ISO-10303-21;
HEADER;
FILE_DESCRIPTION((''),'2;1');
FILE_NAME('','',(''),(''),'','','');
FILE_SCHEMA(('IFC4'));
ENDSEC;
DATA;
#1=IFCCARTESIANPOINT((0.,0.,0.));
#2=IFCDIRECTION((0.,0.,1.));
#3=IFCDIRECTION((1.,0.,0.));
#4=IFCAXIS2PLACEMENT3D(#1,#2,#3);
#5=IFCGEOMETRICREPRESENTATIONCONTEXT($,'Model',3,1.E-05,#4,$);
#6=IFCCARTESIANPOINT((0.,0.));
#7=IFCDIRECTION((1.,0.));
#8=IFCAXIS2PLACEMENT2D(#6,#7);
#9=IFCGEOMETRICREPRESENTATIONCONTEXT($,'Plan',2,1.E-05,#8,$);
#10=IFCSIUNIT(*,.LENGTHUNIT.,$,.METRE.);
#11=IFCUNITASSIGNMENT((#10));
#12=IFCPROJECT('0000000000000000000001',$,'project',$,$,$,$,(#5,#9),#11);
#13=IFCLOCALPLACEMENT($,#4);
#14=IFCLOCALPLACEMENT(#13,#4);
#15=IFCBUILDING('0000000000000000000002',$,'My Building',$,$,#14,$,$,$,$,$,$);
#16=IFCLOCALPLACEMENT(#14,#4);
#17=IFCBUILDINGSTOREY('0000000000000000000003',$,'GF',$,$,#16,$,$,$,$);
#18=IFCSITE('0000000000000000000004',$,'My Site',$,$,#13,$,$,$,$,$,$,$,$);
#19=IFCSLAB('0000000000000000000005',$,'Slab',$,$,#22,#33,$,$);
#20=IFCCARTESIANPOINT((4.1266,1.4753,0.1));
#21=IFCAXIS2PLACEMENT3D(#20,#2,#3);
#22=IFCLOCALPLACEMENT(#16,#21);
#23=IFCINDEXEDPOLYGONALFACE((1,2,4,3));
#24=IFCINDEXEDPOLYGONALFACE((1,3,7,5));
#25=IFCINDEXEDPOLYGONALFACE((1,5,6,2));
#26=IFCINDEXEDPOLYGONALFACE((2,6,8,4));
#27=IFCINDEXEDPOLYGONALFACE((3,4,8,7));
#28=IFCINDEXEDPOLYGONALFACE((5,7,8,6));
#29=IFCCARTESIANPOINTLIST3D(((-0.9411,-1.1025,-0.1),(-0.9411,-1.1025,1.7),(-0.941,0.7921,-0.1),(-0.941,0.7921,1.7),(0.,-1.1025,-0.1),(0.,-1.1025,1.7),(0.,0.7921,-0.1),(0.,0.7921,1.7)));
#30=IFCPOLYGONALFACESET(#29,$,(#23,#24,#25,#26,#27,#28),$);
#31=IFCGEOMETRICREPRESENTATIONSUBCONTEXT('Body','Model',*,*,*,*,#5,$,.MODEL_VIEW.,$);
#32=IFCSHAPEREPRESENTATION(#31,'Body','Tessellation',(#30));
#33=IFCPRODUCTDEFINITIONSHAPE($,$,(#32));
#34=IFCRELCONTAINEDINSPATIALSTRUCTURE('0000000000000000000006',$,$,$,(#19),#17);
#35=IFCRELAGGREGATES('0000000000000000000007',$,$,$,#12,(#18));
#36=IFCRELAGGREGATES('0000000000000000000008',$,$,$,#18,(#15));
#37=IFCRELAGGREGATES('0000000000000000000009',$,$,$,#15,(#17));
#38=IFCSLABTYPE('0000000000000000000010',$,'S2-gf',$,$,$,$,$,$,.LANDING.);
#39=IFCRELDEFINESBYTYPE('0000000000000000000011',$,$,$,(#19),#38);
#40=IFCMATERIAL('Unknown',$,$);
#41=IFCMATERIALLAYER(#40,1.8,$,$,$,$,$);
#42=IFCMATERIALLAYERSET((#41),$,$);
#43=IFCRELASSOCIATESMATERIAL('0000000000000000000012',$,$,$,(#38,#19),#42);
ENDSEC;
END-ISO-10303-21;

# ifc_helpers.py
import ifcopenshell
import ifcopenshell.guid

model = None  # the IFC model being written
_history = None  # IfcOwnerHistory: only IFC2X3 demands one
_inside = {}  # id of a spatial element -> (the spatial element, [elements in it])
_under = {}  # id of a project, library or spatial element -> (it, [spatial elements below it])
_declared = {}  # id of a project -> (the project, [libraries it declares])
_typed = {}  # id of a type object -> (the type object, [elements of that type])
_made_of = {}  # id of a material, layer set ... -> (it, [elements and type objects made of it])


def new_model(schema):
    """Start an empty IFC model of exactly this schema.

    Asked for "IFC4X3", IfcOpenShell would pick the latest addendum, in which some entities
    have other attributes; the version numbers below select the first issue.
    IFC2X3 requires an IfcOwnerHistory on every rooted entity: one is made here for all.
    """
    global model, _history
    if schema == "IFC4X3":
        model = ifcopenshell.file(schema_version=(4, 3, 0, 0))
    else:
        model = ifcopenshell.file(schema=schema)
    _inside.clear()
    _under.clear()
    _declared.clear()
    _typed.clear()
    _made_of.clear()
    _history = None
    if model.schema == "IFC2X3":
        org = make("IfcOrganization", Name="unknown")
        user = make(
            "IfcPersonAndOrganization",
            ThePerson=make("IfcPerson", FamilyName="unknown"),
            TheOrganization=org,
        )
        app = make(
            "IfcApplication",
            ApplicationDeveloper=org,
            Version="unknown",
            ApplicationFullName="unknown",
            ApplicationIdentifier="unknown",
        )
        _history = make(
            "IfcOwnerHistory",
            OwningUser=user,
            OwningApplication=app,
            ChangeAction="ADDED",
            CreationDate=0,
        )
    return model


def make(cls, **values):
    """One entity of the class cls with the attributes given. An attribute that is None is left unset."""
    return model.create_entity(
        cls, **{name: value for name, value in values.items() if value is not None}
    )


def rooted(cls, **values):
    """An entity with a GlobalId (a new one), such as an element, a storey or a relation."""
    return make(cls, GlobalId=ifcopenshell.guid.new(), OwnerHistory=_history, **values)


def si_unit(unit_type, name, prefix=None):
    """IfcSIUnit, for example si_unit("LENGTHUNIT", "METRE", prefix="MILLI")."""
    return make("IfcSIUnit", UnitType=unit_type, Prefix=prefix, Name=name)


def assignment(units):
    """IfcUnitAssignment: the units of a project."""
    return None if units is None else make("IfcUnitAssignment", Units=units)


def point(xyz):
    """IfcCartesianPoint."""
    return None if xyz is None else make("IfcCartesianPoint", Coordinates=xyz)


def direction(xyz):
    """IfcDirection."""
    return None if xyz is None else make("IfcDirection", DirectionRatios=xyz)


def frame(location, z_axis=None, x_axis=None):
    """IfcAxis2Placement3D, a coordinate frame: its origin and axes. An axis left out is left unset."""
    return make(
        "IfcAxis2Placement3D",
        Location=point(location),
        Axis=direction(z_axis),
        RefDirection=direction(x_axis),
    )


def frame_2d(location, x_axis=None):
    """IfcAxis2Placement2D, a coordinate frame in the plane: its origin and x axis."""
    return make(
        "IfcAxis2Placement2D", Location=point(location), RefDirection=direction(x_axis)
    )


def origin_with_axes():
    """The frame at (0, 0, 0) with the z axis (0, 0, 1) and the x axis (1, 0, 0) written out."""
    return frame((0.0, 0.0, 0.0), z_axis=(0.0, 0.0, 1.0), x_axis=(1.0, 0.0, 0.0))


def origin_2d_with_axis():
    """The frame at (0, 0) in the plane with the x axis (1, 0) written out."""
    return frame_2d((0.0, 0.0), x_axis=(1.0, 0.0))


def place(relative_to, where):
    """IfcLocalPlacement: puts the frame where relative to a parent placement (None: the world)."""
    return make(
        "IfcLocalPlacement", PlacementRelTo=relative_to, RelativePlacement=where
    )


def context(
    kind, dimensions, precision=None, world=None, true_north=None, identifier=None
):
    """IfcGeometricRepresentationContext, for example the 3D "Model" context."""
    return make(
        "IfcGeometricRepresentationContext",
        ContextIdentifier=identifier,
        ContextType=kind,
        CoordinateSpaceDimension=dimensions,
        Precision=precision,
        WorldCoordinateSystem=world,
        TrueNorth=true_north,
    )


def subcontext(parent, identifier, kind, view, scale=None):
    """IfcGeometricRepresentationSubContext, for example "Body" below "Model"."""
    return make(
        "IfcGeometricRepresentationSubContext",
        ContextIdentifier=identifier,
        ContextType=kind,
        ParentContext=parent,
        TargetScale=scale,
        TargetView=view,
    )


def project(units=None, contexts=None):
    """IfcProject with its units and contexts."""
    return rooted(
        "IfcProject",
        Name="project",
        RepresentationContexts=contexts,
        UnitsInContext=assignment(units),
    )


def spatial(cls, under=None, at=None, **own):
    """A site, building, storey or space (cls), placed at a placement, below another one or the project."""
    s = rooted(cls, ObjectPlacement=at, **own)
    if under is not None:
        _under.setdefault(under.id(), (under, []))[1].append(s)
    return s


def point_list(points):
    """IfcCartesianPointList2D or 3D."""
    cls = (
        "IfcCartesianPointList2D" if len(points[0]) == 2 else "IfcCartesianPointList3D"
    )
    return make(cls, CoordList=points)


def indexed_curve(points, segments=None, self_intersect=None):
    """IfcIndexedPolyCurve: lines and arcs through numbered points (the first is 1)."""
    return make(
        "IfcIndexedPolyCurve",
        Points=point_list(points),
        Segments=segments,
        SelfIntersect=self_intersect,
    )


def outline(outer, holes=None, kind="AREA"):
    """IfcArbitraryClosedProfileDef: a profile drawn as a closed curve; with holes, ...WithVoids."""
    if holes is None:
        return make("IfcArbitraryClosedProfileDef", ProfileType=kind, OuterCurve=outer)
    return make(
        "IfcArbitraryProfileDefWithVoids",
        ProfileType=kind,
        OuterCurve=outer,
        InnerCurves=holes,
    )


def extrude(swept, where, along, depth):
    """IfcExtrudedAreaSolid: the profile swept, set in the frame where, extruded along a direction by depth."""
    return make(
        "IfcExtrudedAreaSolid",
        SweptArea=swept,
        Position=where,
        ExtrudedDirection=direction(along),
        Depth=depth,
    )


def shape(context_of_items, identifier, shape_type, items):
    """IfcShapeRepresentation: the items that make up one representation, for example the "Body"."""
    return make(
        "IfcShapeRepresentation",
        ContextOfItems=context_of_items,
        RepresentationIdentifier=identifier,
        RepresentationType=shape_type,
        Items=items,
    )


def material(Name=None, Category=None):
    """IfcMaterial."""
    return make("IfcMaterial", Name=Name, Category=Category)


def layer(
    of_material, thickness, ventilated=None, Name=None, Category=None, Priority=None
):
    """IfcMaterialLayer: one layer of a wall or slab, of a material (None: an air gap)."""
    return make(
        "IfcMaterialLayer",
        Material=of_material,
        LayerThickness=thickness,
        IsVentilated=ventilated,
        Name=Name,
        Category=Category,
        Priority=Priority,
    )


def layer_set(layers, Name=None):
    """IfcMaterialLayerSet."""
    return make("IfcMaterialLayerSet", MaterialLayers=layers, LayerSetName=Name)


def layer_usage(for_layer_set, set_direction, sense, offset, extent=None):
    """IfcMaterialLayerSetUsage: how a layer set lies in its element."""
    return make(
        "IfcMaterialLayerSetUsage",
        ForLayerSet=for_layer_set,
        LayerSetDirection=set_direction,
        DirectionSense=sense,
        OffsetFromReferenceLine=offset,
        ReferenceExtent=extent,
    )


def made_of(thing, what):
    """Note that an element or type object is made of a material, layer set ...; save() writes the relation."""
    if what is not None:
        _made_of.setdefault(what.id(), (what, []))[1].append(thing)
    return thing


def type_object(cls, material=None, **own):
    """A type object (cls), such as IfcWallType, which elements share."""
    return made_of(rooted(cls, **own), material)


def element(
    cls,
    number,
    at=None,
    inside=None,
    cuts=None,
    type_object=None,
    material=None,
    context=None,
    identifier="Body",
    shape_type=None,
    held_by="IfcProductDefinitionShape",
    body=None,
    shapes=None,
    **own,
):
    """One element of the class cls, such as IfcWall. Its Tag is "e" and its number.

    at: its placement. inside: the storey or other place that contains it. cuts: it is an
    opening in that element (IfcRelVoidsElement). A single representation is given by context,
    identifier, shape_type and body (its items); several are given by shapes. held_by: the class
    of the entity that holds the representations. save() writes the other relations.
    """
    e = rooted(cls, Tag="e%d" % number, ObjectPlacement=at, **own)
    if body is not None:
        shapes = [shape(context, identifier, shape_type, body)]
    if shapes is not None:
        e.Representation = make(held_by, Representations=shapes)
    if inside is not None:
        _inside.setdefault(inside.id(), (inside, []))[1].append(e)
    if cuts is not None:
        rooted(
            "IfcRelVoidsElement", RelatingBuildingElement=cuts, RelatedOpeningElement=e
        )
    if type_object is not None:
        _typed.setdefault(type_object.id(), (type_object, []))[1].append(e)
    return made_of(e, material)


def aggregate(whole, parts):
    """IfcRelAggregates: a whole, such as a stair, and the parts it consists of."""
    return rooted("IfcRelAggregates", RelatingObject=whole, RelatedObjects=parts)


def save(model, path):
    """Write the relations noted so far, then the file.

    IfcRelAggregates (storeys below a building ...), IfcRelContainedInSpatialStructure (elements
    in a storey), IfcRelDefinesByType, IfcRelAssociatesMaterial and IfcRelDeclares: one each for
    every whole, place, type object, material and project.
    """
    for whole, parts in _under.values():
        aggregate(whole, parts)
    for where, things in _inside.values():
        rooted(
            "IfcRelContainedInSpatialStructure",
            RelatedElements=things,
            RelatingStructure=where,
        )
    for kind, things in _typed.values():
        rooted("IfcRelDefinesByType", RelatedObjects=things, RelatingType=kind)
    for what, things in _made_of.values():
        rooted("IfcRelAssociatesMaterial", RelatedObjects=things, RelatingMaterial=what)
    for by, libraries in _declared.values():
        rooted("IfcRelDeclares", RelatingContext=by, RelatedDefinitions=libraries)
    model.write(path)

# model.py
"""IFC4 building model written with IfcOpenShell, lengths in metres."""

from ifc_helpers import new_model, si_unit, frame, origin_with_axes, origin_2d_with_axis, place, context, subcontext, project, spatial, indexed_curve, outline, extrude, material, layer, layer_set, layer_usage, type_object, element, save


model = new_model("IFC4")

# Units and contexts
model_context = context("Model", 3, precision=1e-05, world=origin_with_axes())
plan_context = context("Plan", 2, precision=1e-05, world=origin_2d_with_axis())
body_context_1 = subcontext(model_context, "Body", "Model", "MODEL_VIEW")
ifc_project = project(units=[si_unit("LENGTHUNIT", "METRE")], contexts=[model_context, plan_context])

# Site, building, storey
site_placement = place(None, origin_with_axes())
site = spatial("IfcSite", under=ifc_project, at=site_placement, Name="My Site")
building_placement = place(site_placement, origin_with_axes())
building = spatial("IfcBuilding", under=site, at=building_placement, Name="My Building")
storey_placement = place(building_placement, origin_with_axes())
storey = spatial("IfcBuildingStorey", under=building, at=storey_placement, Name="GF")

# Slab
ifc_material_1 = material(Name="Unknown")
ifc_layer_1 = layer(ifc_material_1, 1.8)
ifc_layer_set_1 = layer_set([ifc_layer_1])
ifc_layer_usage_1 = layer_usage(ifc_layer_set_1, "AXIS3", "POSITIVE", -0.1)
slab_type_1 = type_object("IfcSlabType", Name="S2-gf", PredefinedType="LANDING", material=ifc_layer_set_1)
slab_1_placement = place(storey_placement, frame((4.1266, 1.4753, 0.1), z_axis=(0.0, 0.0, 1.0), x_axis=(1.0, 0.0, 0.0)))
element("IfcSlab", 1, at=slab_1_placement, inside=storey, type_object=slab_type_1, material=ifc_layer_usage_1, Name="Slab", context=body_context_1, shape_type="SweptSolid", body=[
    extrude(outline(indexed_curve([(0.0, 0.7921), (0.0, -1.1025), (-0.9411, -1.1025), (-0.941, 0.7921), (0.0, 0.7921)])), frame((0.0, 0.0, -0.1), z_axis=(0.0, 0.0, 1.0), x_axis=(1.0, 0.0, 0.0)), (0.0, 0.0, 1.0), 1.8),
])

save(model, "model.ifc")
